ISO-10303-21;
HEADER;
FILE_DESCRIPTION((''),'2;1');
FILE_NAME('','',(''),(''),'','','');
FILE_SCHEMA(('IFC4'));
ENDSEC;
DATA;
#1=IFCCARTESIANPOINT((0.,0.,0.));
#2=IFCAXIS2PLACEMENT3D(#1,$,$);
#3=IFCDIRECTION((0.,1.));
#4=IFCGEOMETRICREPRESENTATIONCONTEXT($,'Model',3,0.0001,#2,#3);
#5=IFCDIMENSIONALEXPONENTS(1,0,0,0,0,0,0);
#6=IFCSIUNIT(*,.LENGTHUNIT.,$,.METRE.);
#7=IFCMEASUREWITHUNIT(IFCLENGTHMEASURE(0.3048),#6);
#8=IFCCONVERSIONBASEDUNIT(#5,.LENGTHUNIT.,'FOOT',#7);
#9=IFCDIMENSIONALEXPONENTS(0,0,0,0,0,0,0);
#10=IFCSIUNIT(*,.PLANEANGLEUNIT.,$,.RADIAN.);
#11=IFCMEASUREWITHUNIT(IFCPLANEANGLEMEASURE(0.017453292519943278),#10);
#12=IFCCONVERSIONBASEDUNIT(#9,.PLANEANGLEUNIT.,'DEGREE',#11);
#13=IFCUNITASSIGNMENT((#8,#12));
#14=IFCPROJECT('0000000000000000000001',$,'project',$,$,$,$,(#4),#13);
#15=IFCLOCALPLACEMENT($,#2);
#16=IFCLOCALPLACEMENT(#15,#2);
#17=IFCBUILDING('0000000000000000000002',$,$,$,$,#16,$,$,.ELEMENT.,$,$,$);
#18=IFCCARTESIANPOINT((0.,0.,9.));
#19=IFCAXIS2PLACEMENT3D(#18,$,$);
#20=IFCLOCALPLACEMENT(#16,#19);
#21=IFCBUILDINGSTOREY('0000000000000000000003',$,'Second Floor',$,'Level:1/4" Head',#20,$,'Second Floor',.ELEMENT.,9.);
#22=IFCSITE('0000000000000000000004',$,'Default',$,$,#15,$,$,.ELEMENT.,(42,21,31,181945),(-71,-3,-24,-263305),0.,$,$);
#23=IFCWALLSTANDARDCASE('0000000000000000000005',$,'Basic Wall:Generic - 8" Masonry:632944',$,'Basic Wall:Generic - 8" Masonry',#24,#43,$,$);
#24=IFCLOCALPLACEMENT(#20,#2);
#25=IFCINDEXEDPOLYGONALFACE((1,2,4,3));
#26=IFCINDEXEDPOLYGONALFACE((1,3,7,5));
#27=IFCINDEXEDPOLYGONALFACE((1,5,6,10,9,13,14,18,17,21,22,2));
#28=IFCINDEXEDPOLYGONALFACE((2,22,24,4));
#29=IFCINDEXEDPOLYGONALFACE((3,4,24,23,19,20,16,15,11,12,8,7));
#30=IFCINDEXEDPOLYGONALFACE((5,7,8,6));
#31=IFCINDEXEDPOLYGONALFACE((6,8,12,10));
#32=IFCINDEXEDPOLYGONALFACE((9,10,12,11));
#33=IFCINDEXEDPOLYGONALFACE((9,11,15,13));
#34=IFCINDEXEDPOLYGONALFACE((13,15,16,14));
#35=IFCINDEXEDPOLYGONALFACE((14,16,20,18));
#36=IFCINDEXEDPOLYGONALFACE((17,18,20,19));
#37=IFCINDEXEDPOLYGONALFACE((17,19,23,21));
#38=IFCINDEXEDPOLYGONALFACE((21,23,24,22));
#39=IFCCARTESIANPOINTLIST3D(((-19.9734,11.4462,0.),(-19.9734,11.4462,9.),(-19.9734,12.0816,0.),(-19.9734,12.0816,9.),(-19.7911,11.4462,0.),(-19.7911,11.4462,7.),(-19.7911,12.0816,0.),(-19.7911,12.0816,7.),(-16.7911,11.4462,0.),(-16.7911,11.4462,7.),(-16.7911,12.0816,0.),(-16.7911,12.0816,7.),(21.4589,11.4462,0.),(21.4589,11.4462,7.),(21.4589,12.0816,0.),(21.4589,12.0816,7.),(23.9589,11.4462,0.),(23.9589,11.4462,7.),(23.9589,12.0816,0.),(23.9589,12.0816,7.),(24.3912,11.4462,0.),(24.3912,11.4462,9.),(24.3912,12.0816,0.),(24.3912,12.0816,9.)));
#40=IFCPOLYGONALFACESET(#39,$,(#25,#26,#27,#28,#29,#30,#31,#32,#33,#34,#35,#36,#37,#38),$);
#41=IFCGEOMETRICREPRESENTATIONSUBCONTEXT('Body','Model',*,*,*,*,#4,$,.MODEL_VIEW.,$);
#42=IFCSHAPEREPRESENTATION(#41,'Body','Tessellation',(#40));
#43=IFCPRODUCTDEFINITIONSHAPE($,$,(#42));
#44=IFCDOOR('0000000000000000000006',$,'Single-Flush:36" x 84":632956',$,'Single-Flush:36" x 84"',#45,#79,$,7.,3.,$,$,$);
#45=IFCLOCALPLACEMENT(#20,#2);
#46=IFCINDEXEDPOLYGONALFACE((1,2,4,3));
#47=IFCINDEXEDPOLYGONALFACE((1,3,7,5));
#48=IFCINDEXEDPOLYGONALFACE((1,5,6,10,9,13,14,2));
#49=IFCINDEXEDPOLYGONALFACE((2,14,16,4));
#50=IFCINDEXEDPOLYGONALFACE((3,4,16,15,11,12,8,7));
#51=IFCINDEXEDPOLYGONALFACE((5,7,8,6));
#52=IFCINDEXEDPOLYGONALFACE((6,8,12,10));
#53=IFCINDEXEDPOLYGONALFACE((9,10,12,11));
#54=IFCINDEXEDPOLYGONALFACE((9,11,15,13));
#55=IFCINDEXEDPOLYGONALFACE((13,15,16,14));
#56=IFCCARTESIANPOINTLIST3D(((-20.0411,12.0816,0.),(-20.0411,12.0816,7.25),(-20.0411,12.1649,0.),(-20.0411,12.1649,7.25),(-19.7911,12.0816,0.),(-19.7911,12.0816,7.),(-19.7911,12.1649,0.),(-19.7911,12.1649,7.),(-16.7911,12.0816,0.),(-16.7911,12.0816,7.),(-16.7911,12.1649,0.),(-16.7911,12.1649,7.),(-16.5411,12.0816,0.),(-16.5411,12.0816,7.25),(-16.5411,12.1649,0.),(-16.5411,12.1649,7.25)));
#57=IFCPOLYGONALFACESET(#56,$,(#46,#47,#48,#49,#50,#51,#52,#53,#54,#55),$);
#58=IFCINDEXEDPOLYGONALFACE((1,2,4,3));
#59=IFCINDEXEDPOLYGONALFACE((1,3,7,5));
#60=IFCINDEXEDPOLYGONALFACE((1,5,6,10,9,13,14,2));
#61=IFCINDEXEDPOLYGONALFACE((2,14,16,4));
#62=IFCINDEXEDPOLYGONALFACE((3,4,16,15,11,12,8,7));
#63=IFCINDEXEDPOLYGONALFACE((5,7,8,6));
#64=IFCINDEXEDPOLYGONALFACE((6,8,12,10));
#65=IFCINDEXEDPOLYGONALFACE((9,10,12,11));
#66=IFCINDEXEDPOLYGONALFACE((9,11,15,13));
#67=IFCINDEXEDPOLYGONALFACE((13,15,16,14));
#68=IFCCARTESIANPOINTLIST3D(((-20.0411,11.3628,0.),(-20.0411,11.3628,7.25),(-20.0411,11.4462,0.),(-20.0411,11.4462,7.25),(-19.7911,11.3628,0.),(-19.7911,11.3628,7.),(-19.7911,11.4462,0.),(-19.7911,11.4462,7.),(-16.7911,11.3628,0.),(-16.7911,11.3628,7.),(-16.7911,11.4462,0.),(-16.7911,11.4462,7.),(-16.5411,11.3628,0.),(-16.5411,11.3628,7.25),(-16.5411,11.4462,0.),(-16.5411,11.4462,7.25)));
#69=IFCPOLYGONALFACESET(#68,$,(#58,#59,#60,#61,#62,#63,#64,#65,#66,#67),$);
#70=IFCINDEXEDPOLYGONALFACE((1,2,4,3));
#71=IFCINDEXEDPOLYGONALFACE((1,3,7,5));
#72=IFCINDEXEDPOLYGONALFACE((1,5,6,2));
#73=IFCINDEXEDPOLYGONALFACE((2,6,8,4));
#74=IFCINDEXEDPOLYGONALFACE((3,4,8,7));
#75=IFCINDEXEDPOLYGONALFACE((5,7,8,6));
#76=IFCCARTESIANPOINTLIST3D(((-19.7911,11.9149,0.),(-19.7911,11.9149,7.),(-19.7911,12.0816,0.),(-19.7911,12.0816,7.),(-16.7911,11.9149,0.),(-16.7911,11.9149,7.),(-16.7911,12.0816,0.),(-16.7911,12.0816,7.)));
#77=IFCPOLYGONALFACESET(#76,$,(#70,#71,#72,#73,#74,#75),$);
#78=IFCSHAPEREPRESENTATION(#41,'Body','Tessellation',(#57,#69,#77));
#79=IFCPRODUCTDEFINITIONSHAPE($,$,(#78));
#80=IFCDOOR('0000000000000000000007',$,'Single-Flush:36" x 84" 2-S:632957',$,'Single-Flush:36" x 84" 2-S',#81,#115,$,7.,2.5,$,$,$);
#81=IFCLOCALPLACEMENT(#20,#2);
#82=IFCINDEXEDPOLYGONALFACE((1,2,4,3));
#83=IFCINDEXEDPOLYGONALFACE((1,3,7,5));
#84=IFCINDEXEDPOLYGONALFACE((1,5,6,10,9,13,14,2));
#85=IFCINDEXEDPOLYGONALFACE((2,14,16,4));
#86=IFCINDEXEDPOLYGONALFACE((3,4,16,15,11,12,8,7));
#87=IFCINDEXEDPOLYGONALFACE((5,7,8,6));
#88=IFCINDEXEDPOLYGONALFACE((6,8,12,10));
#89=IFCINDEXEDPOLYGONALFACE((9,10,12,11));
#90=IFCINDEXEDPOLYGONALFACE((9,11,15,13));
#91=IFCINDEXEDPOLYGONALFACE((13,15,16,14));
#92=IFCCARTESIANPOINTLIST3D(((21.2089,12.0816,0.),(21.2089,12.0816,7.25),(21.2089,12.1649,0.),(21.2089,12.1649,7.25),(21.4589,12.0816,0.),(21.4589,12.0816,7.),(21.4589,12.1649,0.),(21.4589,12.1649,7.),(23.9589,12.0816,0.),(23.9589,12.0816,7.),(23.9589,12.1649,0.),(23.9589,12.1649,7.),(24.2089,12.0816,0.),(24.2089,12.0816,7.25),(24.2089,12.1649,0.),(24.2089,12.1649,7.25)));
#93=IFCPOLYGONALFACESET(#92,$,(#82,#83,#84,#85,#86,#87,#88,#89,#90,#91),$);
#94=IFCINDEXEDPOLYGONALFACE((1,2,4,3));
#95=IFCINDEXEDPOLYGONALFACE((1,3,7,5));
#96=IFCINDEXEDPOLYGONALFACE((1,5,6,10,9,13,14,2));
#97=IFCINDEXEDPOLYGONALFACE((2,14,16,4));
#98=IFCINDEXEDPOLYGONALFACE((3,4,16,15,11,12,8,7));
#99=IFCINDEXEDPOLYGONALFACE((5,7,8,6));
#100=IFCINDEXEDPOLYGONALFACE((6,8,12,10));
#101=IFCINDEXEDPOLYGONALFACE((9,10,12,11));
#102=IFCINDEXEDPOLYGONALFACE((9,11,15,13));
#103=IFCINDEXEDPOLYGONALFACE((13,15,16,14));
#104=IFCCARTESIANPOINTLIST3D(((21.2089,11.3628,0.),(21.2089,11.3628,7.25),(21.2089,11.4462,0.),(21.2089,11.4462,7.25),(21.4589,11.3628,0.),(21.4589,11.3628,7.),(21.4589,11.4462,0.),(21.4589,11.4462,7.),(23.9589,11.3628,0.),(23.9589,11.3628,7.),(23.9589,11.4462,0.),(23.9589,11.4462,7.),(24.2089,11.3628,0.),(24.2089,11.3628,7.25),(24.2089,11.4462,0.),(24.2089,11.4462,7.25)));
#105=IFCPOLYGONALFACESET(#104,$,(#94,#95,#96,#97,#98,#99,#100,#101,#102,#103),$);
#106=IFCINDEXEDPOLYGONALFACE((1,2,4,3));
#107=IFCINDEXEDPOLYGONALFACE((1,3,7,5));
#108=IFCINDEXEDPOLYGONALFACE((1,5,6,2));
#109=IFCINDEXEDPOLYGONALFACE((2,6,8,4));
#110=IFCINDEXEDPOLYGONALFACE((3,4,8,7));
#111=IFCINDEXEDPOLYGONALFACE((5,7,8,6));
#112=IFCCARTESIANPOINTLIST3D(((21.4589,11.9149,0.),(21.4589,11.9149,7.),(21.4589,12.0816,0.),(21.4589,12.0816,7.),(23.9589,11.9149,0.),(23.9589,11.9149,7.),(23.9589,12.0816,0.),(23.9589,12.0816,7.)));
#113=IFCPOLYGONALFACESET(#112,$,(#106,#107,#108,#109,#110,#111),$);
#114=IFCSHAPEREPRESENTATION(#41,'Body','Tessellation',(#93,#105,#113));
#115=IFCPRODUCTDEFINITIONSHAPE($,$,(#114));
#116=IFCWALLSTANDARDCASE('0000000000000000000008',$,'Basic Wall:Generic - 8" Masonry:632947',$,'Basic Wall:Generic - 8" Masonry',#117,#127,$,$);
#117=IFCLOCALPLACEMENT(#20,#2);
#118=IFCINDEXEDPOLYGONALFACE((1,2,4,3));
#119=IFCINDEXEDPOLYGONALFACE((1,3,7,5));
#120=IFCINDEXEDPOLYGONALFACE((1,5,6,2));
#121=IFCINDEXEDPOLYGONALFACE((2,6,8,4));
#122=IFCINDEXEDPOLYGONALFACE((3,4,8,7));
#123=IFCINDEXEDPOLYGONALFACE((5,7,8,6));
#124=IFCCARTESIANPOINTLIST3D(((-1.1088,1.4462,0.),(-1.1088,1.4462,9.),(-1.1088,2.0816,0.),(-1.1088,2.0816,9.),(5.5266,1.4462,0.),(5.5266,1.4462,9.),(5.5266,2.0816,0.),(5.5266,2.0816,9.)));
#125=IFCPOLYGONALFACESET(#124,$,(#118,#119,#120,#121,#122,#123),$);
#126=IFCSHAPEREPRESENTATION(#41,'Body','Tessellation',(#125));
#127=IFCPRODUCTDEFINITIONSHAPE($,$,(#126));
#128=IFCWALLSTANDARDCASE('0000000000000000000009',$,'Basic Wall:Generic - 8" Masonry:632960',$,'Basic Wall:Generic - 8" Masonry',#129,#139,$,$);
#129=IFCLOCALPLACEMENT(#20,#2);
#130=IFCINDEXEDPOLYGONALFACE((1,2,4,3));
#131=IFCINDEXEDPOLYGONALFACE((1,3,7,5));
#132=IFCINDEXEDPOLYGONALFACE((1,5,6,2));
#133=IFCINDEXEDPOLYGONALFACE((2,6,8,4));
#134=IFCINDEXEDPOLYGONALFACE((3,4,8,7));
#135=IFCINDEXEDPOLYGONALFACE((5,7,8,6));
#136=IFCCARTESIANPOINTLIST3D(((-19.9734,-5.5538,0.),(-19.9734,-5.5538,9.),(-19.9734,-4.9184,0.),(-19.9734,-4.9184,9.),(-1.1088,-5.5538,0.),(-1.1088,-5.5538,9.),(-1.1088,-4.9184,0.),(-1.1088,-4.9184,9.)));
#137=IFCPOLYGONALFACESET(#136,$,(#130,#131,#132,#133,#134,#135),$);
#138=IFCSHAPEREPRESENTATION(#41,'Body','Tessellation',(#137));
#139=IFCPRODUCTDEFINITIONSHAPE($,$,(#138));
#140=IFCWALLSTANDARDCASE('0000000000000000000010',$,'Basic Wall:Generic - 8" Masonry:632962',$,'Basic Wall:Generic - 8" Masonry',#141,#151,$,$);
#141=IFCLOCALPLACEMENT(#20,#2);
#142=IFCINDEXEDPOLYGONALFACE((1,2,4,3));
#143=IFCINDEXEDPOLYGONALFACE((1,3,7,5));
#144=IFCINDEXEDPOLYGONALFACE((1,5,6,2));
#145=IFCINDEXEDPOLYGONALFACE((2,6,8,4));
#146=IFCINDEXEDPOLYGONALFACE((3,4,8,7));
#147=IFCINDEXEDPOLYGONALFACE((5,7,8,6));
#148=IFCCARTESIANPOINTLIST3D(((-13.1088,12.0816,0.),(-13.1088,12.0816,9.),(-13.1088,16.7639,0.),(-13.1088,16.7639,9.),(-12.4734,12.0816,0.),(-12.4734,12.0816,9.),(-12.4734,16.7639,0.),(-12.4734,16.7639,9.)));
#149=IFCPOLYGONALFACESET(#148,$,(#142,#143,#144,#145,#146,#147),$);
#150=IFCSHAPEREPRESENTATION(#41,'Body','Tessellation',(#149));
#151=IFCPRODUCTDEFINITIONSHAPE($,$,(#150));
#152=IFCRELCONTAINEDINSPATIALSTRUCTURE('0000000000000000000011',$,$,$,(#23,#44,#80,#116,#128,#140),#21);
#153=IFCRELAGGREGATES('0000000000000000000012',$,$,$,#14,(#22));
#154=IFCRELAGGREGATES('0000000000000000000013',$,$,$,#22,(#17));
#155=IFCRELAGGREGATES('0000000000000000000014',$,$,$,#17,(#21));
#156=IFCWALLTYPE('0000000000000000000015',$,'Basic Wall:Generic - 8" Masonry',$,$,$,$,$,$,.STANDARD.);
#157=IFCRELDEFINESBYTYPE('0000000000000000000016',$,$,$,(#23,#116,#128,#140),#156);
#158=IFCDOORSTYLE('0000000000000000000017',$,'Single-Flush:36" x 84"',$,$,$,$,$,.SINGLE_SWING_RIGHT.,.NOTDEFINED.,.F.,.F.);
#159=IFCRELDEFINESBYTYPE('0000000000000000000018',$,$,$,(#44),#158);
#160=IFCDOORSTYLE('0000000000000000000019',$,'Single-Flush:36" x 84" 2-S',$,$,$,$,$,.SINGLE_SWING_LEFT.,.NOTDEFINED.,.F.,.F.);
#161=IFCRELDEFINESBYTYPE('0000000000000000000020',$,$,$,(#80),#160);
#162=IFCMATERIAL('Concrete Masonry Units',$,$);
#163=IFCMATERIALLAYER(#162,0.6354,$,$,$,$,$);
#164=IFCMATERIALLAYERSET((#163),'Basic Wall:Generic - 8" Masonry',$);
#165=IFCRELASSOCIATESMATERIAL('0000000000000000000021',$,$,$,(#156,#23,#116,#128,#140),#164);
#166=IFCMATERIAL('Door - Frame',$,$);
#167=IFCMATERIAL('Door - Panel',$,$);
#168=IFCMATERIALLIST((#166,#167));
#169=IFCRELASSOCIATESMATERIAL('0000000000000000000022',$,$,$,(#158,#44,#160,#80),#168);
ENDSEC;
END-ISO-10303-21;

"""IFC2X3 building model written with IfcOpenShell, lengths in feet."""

from ifc_helpers import new_model, entity, si_unit, converted_unit, direction, frame, frame_2d, origin, place, context, subcontext, project, spatial, polyline, rectangle, outline, extrude, source, transform, mapped, material, material_list, layer, layer_set, layer_usage, type_object, type_shapes, element, fill, save


model = new_model("IFC2X3")

# Units and contexts
model_context = context("Model", 3, precision=0.0001, world=origin(), true_north=direction((0.0, 1.0)))
body_context = subcontext(model_context, "Body", "Model", "MODEL_VIEW")
ifc_project = project(units=[converted_unit("LENGTHUNIT", "FOOT", entity("IfcLengthMeasure", 0.3048), si_unit("LENGTHUNIT", "METRE"), dimensions=[1, 0, 0, 0, 0, 0, 0]), converted_unit("PLANEANGLEUNIT", "DEGREE", entity("IfcPlaneAngleMeasure", 0.017453292519943278), si_unit("PLANEANGLEUNIT", "RADIAN"), dimensions=[0, 0, 0, 0, 0, 0, 0])], contexts=[model_context])

# Site, building, storey
site_placement = place(None, origin())
site = spatial("IfcSite", under=ifc_project, at=site_placement, Name="Default", CompositionType="ELEMENT", RefLatitude=(42, 21, 31, 181945), RefLongitude=(-71, -3, -24, -263305), RefElevation=0.0)
building_placement = place(site_placement, origin())
building = spatial("IfcBuilding", under=site, at=building_placement, CompositionType="ELEMENT")
storey_placement = place(building_placement, frame((0.0, 0.0, 9.0)))
storey = spatial("IfcBuildingStorey", under=building, at=storey_placement, Name="Second Floor", ObjectType="Level:1/4\" Head", LongName="Second Floor", CompositionType="ELEMENT", Elevation=9.0)

# Shared definitions
ifc_material_1 = material(Name="Concrete Masonry Units")
ifc_layer = layer(ifc_material_1, 0.6354)
ifc_layer_set = layer_set([ifc_layer], Name="Basic Wall:Generic - 8\" Masonry")
wall_type = type_object("IfcWallType", Name="Basic Wall:Generic - 8\" Masonry", PredefinedType="STANDARD", material=ifc_layer_set)

# Wall, openings, doors
ifc_layer_usage_1 = layer_usage(ifc_layer_set, "AXIS2", "NEGATIVE", 0.3177)
wall_1_placement = place(storey_placement, frame((-19.9734, 11.7639, 0.0)))
wall_1 = element("IfcWallStandardCase", 1, at=wall_1_placement, inside=storey, type_object=wall_type, material=ifc_layer_usage_1, Name="Basic Wall:Generic - 8\" Masonry:632944", ObjectType="Basic Wall:Generic - 8\" Masonry", context=body_context, shape_type="SweptSolid", body=[
    extrude(rectangle(XDim=44.3646, YDim=0.6354, at=frame_2d((22.1823, 0.0), x_axis=(-1.0, 0.0))), origin(), (0.0, 0.0, 1.0), 9.0),
])
opening_1_placement = place(wall_1_placement, frame((0.1823, -0.3177, 0.0)))
opening_1 = element("IfcOpeningElement", 2, at=opening_1_placement, cuts=wall_1, ObjectType="Opening", context=body_context, shape_type="SweptSolid", body=[
    extrude(rectangle(XDim=3.0, YDim=7.0, at=frame_2d((3.5, 1.5), x_axis=(0.0, 1.0))), frame((0.0, 0.0, 0.0), z_axis=(0.0, 1.0, 0.0), x_axis=(0.0, 0.0, 1.0)), (0.0, 0.0, 1.0), 0.6354),
])
opening_2_placement = place(wall_1_placement, frame((41.4323, -0.3177, 0.0)))
opening_2 = element("IfcOpeningElement", 3, at=opening_2_placement, cuts=wall_1, ObjectType="Opening", context=body_context, shape_type="SweptSolid", body=[
    extrude(rectangle(XDim=2.5, YDim=7.0, at=frame_2d((3.5, 1.25), x_axis=(0.0, -1.0))), frame((0.0, 0.0, 0.0), z_axis=(0.0, 1.0, 0.0), x_axis=(0.0, 0.0, 1.0)), (0.0, 0.0, 1.0), 0.6354),
])
ifc_material_2 = material(Name="Door - Frame")
ifc_material_3 = material(Name="Door - Panel")
ifc_material_list_1 = material_list([ifc_material_2, ifc_material_3])
door_style_1 = type_object("IfcDoorStyle", Name="Single-Flush:36\" x 84\"", ConstructionType="NOTDEFINED", OperationType="SINGLE_SWING_RIGHT", ParameterTakesPrecedence=False, Sizeable=False, material=ifc_material_list_1)
shared_shape_1 = source(origin(), body_context, "Body", "SweptSolid", [
    extrude(outline(polyline([(-1.75, -3.6875), (1.75, -3.6875), (1.75, 3.5625), (1.5, 3.5625), (1.5, -3.4375), (-1.5, -3.4375), (-1.5, 3.5625), (-1.75, 3.5625), (-1.75, -3.6875)])), frame((1.5, 0.6354, 3.5625), z_axis=(0.0, 1.0, 0.0), x_axis=(1.0, 0.0, 0.0)), (0.0, 0.0, 1.0), 0.0833),
    extrude(outline(polyline([(-3.6875, -1.75), (3.5625, -1.75), (3.5625, -1.5), (-3.4375, -1.5), (-3.4375, 1.5), (3.5625, 1.5), (3.5625, 1.75), (-3.6875, 1.75), (-3.6875, -1.75)])), frame((1.5, -0.0833, 3.5625), z_axis=(0.0, 1.0, 0.0), x_axis=(0.0, 0.0, -1.0)), (0.0, 0.0, 1.0), 0.0833),
    extrude(rectangle(XDim=0.1667, YDim=3.0, at=frame_2d((0.0, 0.0), x_axis=(1.0, 0.0))), frame((1.5, 0.5521, 0.0), z_axis=(0.0, 0.0, 1.0), x_axis=(0.0, 1.0, 0.0)), (0.0, 0.0, 1.0), 7.0),
])
type_shapes(door_style_1, [shared_shape_1])
door_1_placement = place(opening_1_placement, origin())
door_1 = element("IfcDoor", 4, at=door_1_placement, inside=storey, type_object=door_style_1, material=ifc_material_list_1, Name="Single-Flush:36\" x 84\":632956", ObjectType="Single-Flush:36\" x 84\"", OverallHeight=7.0, OverallWidth=3.0, context=body_context, shape_type="MappedRepresentation", body=[
    mapped(shared_shape_1, transform((0.0, 0.0, 0.0), scale=1.0)),
])
fill(opening_1, door_1)
door_style_2 = type_object("IfcDoorStyle", Name="Single-Flush:36\" x 84\" 2-S", ConstructionType="NOTDEFINED", OperationType="SINGLE_SWING_LEFT", ParameterTakesPrecedence=False, Sizeable=False, material=ifc_material_list_1)
shared_shape_2 = source(origin(), body_context, "Body", "SweptSolid", [
    extrude(outline(polyline([(-1.5, -3.6875), (1.5, -3.6875), (1.5, 3.5625), (1.25, 3.5625), (1.25, -3.4375), (-1.25, -3.4375), (-1.25, 3.5625), (-1.5, 3.5625), (-1.5, -3.6875)])), frame((1.25, 0.7187, 3.5625), z_axis=(0.0, -1.0, 0.0), x_axis=(-1.0, 0.0, 0.0)), (0.0, 0.0, 1.0), 0.0833),
    extrude(outline(polyline([(-3.6875, -1.5), (3.5625, -1.5), (3.5625, -1.25), (-3.4375, -1.25), (-3.4375, 1.25), (3.5625, 1.25), (3.5625, 1.5), (-3.6875, 1.5), (-3.6875, -1.5)])), frame((1.25, 0.0, 3.5625), z_axis=(0.0, -1.0, 0.0), x_axis=(0.0, 0.0, -1.0)), (0.0, 0.0, 1.0), 0.0833),
    extrude(rectangle(XDim=2.5, YDim=0.1667, at=frame_2d((0.0, 0.0), x_axis=(1.0, 0.0))), frame((1.25, 0.5521, 0.0)), (0.0, 0.0, 1.0), 7.0),
])
type_shapes(door_style_2, [shared_shape_2])
door_2_placement = place(opening_2_placement, origin())
door_2 = element("IfcDoor", 5, at=door_2_placement, inside=storey, type_object=door_style_2, material=ifc_material_list_1, Name="Single-Flush:36\" x 84\" 2-S:632957", ObjectType="Single-Flush:36\" x 84\" 2-S", OverallHeight=7.0, OverallWidth=2.5, context=body_context, shape_type="MappedRepresentation", body=[
    mapped(shared_shape_2, transform((0.0, 0.0, 0.0), scale=1.0)),
])
fill(opening_2, door_2)

# Walls
ifc_layer_usage_2 = layer_usage(ifc_layer_set, "AXIS2", "NEGATIVE", 0.3177)
wall_2_placement = place(storey_placement, frame((-1.1088, 1.7639, 0.0)))
element("IfcWallStandardCase", 6, at=wall_2_placement, inside=storey, type_object=wall_type, material=ifc_layer_usage_2, Name="Basic Wall:Generic - 8\" Masonry:632947", ObjectType="Basic Wall:Generic - 8\" Masonry", context=body_context, shape_type="SweptSolid", body=[
    extrude(rectangle(XDim=6.6354, YDim=0.6354, at=frame_2d((3.3177, 0.0), x_axis=(-1.0, 0.0))), origin(), (0.0, 0.0, 1.0), 9.0),
])
ifc_layer_usage_3 = layer_usage(ifc_layer_set, "AXIS2", "NEGATIVE", 0.3177)
wall_3_placement = place(storey_placement, frame((-1.1088, -5.2361, 0.0), z_axis=(0.0, 0.0, 1.0), x_axis=(-1.0, 0.0, 0.0)))
element("IfcWallStandardCase", 7, at=wall_3_placement, inside=storey, type_object=wall_type, material=ifc_layer_usage_3, Name="Basic Wall:Generic - 8\" Masonry:632960", ObjectType="Basic Wall:Generic - 8\" Masonry", context=body_context, shape_type="SweptSolid", body=[
    extrude(rectangle(XDim=18.8646, YDim=0.6354, at=frame_2d((9.4323, 0.0), x_axis=(-1.0, 0.0))), origin(), (0.0, 0.0, 1.0), 9.0),
])
ifc_layer_usage_4 = layer_usage(ifc_layer_set, "AXIS2", "NEGATIVE", 0.3177)
wall_4_placement = place(storey_placement, frame((-12.7911, 12.0816, 0.0), z_axis=(0.0, 0.0, 1.0), x_axis=(0.0, 1.0, 0.0)))
element("IfcWallStandardCase", 8, at=wall_4_placement, inside=storey, type_object=wall_type, material=ifc_layer_usage_4, Name="Basic Wall:Generic - 8\" Masonry:632962", ObjectType="Basic Wall:Generic - 8\" Masonry", context=body_context, shape_type="SweptSolid", body=[
    extrude(rectangle(XDim=4.6823, YDim=0.6354, at=frame_2d((2.3411, 0.0), x_axis=(-1.0, 0.0))), origin(), (0.0, 0.0, 1.0), 9.0),
])

save(model, "model.ifc")
